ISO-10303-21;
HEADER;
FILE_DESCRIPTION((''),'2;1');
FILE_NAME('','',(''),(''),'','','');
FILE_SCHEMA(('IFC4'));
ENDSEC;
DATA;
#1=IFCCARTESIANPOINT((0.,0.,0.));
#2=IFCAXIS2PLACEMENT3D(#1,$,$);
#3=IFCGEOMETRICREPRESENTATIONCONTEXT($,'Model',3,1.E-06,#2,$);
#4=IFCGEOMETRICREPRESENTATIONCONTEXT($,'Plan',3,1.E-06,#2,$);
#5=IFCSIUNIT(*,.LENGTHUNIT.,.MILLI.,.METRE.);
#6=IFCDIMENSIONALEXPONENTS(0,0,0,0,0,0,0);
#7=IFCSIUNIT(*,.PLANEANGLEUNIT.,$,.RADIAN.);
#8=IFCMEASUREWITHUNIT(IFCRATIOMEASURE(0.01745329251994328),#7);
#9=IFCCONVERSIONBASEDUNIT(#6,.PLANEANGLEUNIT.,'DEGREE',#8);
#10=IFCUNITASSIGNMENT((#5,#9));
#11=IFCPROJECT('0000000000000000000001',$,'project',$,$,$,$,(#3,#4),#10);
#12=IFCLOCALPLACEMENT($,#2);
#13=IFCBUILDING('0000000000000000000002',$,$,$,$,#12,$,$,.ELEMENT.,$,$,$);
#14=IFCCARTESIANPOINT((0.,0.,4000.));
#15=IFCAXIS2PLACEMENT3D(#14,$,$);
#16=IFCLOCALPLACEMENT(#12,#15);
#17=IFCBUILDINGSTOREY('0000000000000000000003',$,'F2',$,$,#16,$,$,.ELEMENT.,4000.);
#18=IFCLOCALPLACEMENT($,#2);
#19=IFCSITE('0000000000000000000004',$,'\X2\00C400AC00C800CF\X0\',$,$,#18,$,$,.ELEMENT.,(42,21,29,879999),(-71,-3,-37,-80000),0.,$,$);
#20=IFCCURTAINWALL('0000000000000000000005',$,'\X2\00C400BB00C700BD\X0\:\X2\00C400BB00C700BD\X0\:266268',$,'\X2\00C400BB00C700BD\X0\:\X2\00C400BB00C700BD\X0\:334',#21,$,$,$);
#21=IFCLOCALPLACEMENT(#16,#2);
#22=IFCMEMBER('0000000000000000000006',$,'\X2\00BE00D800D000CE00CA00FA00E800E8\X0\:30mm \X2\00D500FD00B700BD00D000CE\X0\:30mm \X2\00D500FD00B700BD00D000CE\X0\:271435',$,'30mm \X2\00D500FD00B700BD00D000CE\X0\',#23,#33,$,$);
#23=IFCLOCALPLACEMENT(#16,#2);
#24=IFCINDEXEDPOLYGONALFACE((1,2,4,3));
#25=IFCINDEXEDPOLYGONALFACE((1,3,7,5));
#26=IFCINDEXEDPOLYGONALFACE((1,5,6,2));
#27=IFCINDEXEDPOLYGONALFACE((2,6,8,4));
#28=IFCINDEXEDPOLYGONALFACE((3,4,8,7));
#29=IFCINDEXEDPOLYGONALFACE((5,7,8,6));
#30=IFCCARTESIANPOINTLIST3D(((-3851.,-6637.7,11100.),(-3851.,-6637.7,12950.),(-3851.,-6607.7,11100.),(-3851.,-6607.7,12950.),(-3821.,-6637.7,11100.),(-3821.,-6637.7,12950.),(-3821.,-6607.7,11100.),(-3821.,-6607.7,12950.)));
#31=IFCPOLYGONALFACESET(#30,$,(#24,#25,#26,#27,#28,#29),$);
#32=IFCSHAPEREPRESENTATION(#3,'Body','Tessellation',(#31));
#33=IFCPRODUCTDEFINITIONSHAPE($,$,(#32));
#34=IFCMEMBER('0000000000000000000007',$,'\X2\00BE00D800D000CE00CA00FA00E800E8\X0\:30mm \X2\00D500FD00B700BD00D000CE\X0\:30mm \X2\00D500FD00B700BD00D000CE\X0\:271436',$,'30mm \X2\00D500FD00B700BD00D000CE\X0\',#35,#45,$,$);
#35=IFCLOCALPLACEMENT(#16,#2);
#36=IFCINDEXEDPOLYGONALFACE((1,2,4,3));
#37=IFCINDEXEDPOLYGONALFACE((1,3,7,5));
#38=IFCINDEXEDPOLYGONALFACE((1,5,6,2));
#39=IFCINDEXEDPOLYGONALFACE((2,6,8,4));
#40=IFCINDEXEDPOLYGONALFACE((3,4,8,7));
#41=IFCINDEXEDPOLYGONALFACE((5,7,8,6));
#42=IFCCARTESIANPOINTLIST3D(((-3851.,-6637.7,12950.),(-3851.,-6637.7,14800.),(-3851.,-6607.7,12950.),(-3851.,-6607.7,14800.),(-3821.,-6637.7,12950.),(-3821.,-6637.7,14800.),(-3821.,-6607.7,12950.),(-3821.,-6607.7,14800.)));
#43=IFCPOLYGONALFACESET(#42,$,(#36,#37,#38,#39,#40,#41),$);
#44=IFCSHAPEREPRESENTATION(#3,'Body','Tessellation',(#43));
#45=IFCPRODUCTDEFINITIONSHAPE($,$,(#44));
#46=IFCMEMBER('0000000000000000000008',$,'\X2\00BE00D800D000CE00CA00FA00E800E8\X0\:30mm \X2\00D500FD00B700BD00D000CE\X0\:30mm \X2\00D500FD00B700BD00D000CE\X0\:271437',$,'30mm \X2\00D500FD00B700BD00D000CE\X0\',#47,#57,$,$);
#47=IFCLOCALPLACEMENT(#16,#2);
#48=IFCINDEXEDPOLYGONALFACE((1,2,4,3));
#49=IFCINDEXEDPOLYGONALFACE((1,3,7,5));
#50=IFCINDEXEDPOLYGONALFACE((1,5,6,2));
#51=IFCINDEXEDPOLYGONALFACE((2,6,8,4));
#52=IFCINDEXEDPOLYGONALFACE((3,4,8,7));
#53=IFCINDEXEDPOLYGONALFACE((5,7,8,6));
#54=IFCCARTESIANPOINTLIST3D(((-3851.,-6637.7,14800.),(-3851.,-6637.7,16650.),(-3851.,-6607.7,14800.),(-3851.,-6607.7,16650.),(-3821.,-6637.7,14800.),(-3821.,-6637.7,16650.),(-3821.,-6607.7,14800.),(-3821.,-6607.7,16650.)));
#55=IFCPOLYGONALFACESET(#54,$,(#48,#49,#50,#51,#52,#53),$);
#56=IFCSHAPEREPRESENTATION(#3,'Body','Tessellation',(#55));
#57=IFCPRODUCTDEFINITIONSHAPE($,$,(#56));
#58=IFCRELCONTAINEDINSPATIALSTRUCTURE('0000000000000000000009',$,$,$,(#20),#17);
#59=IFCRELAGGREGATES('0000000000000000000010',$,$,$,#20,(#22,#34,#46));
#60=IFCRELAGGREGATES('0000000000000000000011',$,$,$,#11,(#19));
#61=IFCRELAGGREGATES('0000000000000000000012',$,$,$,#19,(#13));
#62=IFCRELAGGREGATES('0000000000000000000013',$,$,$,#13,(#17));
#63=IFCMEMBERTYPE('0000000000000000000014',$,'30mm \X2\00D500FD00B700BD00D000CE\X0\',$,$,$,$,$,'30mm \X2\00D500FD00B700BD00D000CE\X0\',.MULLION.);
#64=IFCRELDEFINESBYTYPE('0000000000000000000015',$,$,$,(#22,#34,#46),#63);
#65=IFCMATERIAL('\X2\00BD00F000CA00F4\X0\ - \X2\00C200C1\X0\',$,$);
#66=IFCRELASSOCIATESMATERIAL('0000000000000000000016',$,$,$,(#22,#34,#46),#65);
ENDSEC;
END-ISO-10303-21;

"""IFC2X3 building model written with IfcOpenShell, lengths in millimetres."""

from ifc_helpers import new_model, entity, si_unit, converted_unit, frame, origin, origin_2d_with_axis, place, context, project, spatial, rectangle, extrude, source, transform, mapped, material, type_object, type_shapes, element, aggregate, save


model = new_model("IFC2X3")

# Units and contexts
model_context = context("Model", 3, precision=1e-06, world=origin())
plan_context = context("Plan", 3, precision=1e-06, world=origin())
ifc_project = project(units=[si_unit("LENGTHUNIT", "METRE", prefix="MILLI"), converted_unit("PLANEANGLEUNIT", "DEGREE", entity("IfcRatioMeasure", 0.01745329251994328), si_unit("PLANEANGLEUNIT", "RADIAN"), dimensions=[0, 0, 0, 0, 0, 0, 0])], contexts=[model_context, plan_context])

# Site, building, storey
site_placement = place(None, origin())
site = spatial("IfcSite", under=ifc_project, at=site_placement, Name="Ä¬ÈÏ", CompositionType="ELEMENT", RefLatitude=(42, 21, 29, 879999), RefLongitude=(-71, -3, -37, -80000), RefElevation=0.0)
building_placement = place(None, origin())
building = spatial("IfcBuilding", under=site, at=building_placement, CompositionType="ELEMENT")
storey_placement = place(building_placement, frame((0.0, 0.0, 4000.0)))
storey = spatial("IfcBuildingStorey", under=building, at=storey_placement, Name="F2", CompositionType="ELEMENT", Elevation=4000.0)

# Curtain wall, members
curtain_wall_placement = place(storey_placement, origin())
curtain_wall = element("IfcCurtainWall", 1, at=curtain_wall_placement, inside=storey, Name="Ä»Ç½:Ä»Ç½:266268", ObjectType="Ä»Ç½:Ä»Ç½:334")
ifc_material_1 = material(Name="½ðÊô - ÂÁ")
placement_1 = place(building_placement, frame((0.0, 0.0, 15100.0)))
placement_2 = place(building_placement, frame((0.0, 0.0, 18800.0)))
member_type_1 = type_object("IfcMemberType", Name="30mm Õý·½ÐÎ", ElementType="30mm Õý·½ÐÎ", PredefinedType="MULLION")
shared_shape_1 = source(origin(), model_context, "Body", "SweptSolid", [
    extrude(rectangle(XDim=30.0, YDim=30.0, at=origin_2d_with_axis()), frame((0.0, 0.0, -1850.0), z_axis=(0.0, 0.0, 1.0), x_axis=(-1.0, 0.0, 0.0)), (0.0, 0.0, 1.0), 1850.0),
])
type_shapes(member_type_1, [shared_shape_1])
member_1_placement = place(placement_1, frame((-3836.0, -6622.7, 0.0), z_axis=(0.0, 0.0, -1.0), x_axis=(1.0, 0.0, 0.0)))
member_1 = element("IfcMember", 2, at=member_1_placement, type_object=member_type_1, material=ifc_material_1, Name="¾ØÐÎÊúèè:30mm Õý·½ÐÎ:30mm Õý·½ÐÎ:271435", ObjectType="30mm Õý·½ÐÎ", context=model_context, shape_type="MappedRepresentation", body=[
    mapped(shared_shape_1, transform((0.0, 0.0, 0.0), scale=1.0)),
])
member_2_placement = place(placement_1, frame((-3836.0, -6622.7, 1850.0), z_axis=(0.0, 0.0, -1.0), x_axis=(1.0, 0.0, 0.0)))
member_2 = element("IfcMember", 3, at=member_2_placement, type_object=member_type_1, material=ifc_material_1, Name="¾ØÐÎÊúèè:30mm Õý·½ÐÎ:30mm Õý·½ÐÎ:271436", ObjectType="30mm Õý·½ÐÎ", context=model_context, shape_type="MappedRepresentation", body=[
    mapped(shared_shape_1, transform((0.0, 0.0, 0.0), scale=1.0)),
])
member_3_placement = place(placement_2, frame((-3836.0, -6622.7, 0.0), z_axis=(0.0, 0.0, -1.0), x_axis=(1.0, 0.0, 0.0)))
member_3 = element("IfcMember", 4, at=member_3_placement, type_object=member_type_1, material=ifc_material_1, Name="¾ØÐÎÊúèè:30mm Õý·½ÐÎ:30mm Õý·½ÐÎ:271437", ObjectType="30mm Õý·½ÐÎ", context=model_context, shape_type="MappedRepresentation", body=[
    mapped(shared_shape_1, transform((0.0, 0.0, 0.0), scale=1.0)),
])
aggregate(curtain_wall, [member_1, member_2, member_3])

save(model, "model.ifc")
